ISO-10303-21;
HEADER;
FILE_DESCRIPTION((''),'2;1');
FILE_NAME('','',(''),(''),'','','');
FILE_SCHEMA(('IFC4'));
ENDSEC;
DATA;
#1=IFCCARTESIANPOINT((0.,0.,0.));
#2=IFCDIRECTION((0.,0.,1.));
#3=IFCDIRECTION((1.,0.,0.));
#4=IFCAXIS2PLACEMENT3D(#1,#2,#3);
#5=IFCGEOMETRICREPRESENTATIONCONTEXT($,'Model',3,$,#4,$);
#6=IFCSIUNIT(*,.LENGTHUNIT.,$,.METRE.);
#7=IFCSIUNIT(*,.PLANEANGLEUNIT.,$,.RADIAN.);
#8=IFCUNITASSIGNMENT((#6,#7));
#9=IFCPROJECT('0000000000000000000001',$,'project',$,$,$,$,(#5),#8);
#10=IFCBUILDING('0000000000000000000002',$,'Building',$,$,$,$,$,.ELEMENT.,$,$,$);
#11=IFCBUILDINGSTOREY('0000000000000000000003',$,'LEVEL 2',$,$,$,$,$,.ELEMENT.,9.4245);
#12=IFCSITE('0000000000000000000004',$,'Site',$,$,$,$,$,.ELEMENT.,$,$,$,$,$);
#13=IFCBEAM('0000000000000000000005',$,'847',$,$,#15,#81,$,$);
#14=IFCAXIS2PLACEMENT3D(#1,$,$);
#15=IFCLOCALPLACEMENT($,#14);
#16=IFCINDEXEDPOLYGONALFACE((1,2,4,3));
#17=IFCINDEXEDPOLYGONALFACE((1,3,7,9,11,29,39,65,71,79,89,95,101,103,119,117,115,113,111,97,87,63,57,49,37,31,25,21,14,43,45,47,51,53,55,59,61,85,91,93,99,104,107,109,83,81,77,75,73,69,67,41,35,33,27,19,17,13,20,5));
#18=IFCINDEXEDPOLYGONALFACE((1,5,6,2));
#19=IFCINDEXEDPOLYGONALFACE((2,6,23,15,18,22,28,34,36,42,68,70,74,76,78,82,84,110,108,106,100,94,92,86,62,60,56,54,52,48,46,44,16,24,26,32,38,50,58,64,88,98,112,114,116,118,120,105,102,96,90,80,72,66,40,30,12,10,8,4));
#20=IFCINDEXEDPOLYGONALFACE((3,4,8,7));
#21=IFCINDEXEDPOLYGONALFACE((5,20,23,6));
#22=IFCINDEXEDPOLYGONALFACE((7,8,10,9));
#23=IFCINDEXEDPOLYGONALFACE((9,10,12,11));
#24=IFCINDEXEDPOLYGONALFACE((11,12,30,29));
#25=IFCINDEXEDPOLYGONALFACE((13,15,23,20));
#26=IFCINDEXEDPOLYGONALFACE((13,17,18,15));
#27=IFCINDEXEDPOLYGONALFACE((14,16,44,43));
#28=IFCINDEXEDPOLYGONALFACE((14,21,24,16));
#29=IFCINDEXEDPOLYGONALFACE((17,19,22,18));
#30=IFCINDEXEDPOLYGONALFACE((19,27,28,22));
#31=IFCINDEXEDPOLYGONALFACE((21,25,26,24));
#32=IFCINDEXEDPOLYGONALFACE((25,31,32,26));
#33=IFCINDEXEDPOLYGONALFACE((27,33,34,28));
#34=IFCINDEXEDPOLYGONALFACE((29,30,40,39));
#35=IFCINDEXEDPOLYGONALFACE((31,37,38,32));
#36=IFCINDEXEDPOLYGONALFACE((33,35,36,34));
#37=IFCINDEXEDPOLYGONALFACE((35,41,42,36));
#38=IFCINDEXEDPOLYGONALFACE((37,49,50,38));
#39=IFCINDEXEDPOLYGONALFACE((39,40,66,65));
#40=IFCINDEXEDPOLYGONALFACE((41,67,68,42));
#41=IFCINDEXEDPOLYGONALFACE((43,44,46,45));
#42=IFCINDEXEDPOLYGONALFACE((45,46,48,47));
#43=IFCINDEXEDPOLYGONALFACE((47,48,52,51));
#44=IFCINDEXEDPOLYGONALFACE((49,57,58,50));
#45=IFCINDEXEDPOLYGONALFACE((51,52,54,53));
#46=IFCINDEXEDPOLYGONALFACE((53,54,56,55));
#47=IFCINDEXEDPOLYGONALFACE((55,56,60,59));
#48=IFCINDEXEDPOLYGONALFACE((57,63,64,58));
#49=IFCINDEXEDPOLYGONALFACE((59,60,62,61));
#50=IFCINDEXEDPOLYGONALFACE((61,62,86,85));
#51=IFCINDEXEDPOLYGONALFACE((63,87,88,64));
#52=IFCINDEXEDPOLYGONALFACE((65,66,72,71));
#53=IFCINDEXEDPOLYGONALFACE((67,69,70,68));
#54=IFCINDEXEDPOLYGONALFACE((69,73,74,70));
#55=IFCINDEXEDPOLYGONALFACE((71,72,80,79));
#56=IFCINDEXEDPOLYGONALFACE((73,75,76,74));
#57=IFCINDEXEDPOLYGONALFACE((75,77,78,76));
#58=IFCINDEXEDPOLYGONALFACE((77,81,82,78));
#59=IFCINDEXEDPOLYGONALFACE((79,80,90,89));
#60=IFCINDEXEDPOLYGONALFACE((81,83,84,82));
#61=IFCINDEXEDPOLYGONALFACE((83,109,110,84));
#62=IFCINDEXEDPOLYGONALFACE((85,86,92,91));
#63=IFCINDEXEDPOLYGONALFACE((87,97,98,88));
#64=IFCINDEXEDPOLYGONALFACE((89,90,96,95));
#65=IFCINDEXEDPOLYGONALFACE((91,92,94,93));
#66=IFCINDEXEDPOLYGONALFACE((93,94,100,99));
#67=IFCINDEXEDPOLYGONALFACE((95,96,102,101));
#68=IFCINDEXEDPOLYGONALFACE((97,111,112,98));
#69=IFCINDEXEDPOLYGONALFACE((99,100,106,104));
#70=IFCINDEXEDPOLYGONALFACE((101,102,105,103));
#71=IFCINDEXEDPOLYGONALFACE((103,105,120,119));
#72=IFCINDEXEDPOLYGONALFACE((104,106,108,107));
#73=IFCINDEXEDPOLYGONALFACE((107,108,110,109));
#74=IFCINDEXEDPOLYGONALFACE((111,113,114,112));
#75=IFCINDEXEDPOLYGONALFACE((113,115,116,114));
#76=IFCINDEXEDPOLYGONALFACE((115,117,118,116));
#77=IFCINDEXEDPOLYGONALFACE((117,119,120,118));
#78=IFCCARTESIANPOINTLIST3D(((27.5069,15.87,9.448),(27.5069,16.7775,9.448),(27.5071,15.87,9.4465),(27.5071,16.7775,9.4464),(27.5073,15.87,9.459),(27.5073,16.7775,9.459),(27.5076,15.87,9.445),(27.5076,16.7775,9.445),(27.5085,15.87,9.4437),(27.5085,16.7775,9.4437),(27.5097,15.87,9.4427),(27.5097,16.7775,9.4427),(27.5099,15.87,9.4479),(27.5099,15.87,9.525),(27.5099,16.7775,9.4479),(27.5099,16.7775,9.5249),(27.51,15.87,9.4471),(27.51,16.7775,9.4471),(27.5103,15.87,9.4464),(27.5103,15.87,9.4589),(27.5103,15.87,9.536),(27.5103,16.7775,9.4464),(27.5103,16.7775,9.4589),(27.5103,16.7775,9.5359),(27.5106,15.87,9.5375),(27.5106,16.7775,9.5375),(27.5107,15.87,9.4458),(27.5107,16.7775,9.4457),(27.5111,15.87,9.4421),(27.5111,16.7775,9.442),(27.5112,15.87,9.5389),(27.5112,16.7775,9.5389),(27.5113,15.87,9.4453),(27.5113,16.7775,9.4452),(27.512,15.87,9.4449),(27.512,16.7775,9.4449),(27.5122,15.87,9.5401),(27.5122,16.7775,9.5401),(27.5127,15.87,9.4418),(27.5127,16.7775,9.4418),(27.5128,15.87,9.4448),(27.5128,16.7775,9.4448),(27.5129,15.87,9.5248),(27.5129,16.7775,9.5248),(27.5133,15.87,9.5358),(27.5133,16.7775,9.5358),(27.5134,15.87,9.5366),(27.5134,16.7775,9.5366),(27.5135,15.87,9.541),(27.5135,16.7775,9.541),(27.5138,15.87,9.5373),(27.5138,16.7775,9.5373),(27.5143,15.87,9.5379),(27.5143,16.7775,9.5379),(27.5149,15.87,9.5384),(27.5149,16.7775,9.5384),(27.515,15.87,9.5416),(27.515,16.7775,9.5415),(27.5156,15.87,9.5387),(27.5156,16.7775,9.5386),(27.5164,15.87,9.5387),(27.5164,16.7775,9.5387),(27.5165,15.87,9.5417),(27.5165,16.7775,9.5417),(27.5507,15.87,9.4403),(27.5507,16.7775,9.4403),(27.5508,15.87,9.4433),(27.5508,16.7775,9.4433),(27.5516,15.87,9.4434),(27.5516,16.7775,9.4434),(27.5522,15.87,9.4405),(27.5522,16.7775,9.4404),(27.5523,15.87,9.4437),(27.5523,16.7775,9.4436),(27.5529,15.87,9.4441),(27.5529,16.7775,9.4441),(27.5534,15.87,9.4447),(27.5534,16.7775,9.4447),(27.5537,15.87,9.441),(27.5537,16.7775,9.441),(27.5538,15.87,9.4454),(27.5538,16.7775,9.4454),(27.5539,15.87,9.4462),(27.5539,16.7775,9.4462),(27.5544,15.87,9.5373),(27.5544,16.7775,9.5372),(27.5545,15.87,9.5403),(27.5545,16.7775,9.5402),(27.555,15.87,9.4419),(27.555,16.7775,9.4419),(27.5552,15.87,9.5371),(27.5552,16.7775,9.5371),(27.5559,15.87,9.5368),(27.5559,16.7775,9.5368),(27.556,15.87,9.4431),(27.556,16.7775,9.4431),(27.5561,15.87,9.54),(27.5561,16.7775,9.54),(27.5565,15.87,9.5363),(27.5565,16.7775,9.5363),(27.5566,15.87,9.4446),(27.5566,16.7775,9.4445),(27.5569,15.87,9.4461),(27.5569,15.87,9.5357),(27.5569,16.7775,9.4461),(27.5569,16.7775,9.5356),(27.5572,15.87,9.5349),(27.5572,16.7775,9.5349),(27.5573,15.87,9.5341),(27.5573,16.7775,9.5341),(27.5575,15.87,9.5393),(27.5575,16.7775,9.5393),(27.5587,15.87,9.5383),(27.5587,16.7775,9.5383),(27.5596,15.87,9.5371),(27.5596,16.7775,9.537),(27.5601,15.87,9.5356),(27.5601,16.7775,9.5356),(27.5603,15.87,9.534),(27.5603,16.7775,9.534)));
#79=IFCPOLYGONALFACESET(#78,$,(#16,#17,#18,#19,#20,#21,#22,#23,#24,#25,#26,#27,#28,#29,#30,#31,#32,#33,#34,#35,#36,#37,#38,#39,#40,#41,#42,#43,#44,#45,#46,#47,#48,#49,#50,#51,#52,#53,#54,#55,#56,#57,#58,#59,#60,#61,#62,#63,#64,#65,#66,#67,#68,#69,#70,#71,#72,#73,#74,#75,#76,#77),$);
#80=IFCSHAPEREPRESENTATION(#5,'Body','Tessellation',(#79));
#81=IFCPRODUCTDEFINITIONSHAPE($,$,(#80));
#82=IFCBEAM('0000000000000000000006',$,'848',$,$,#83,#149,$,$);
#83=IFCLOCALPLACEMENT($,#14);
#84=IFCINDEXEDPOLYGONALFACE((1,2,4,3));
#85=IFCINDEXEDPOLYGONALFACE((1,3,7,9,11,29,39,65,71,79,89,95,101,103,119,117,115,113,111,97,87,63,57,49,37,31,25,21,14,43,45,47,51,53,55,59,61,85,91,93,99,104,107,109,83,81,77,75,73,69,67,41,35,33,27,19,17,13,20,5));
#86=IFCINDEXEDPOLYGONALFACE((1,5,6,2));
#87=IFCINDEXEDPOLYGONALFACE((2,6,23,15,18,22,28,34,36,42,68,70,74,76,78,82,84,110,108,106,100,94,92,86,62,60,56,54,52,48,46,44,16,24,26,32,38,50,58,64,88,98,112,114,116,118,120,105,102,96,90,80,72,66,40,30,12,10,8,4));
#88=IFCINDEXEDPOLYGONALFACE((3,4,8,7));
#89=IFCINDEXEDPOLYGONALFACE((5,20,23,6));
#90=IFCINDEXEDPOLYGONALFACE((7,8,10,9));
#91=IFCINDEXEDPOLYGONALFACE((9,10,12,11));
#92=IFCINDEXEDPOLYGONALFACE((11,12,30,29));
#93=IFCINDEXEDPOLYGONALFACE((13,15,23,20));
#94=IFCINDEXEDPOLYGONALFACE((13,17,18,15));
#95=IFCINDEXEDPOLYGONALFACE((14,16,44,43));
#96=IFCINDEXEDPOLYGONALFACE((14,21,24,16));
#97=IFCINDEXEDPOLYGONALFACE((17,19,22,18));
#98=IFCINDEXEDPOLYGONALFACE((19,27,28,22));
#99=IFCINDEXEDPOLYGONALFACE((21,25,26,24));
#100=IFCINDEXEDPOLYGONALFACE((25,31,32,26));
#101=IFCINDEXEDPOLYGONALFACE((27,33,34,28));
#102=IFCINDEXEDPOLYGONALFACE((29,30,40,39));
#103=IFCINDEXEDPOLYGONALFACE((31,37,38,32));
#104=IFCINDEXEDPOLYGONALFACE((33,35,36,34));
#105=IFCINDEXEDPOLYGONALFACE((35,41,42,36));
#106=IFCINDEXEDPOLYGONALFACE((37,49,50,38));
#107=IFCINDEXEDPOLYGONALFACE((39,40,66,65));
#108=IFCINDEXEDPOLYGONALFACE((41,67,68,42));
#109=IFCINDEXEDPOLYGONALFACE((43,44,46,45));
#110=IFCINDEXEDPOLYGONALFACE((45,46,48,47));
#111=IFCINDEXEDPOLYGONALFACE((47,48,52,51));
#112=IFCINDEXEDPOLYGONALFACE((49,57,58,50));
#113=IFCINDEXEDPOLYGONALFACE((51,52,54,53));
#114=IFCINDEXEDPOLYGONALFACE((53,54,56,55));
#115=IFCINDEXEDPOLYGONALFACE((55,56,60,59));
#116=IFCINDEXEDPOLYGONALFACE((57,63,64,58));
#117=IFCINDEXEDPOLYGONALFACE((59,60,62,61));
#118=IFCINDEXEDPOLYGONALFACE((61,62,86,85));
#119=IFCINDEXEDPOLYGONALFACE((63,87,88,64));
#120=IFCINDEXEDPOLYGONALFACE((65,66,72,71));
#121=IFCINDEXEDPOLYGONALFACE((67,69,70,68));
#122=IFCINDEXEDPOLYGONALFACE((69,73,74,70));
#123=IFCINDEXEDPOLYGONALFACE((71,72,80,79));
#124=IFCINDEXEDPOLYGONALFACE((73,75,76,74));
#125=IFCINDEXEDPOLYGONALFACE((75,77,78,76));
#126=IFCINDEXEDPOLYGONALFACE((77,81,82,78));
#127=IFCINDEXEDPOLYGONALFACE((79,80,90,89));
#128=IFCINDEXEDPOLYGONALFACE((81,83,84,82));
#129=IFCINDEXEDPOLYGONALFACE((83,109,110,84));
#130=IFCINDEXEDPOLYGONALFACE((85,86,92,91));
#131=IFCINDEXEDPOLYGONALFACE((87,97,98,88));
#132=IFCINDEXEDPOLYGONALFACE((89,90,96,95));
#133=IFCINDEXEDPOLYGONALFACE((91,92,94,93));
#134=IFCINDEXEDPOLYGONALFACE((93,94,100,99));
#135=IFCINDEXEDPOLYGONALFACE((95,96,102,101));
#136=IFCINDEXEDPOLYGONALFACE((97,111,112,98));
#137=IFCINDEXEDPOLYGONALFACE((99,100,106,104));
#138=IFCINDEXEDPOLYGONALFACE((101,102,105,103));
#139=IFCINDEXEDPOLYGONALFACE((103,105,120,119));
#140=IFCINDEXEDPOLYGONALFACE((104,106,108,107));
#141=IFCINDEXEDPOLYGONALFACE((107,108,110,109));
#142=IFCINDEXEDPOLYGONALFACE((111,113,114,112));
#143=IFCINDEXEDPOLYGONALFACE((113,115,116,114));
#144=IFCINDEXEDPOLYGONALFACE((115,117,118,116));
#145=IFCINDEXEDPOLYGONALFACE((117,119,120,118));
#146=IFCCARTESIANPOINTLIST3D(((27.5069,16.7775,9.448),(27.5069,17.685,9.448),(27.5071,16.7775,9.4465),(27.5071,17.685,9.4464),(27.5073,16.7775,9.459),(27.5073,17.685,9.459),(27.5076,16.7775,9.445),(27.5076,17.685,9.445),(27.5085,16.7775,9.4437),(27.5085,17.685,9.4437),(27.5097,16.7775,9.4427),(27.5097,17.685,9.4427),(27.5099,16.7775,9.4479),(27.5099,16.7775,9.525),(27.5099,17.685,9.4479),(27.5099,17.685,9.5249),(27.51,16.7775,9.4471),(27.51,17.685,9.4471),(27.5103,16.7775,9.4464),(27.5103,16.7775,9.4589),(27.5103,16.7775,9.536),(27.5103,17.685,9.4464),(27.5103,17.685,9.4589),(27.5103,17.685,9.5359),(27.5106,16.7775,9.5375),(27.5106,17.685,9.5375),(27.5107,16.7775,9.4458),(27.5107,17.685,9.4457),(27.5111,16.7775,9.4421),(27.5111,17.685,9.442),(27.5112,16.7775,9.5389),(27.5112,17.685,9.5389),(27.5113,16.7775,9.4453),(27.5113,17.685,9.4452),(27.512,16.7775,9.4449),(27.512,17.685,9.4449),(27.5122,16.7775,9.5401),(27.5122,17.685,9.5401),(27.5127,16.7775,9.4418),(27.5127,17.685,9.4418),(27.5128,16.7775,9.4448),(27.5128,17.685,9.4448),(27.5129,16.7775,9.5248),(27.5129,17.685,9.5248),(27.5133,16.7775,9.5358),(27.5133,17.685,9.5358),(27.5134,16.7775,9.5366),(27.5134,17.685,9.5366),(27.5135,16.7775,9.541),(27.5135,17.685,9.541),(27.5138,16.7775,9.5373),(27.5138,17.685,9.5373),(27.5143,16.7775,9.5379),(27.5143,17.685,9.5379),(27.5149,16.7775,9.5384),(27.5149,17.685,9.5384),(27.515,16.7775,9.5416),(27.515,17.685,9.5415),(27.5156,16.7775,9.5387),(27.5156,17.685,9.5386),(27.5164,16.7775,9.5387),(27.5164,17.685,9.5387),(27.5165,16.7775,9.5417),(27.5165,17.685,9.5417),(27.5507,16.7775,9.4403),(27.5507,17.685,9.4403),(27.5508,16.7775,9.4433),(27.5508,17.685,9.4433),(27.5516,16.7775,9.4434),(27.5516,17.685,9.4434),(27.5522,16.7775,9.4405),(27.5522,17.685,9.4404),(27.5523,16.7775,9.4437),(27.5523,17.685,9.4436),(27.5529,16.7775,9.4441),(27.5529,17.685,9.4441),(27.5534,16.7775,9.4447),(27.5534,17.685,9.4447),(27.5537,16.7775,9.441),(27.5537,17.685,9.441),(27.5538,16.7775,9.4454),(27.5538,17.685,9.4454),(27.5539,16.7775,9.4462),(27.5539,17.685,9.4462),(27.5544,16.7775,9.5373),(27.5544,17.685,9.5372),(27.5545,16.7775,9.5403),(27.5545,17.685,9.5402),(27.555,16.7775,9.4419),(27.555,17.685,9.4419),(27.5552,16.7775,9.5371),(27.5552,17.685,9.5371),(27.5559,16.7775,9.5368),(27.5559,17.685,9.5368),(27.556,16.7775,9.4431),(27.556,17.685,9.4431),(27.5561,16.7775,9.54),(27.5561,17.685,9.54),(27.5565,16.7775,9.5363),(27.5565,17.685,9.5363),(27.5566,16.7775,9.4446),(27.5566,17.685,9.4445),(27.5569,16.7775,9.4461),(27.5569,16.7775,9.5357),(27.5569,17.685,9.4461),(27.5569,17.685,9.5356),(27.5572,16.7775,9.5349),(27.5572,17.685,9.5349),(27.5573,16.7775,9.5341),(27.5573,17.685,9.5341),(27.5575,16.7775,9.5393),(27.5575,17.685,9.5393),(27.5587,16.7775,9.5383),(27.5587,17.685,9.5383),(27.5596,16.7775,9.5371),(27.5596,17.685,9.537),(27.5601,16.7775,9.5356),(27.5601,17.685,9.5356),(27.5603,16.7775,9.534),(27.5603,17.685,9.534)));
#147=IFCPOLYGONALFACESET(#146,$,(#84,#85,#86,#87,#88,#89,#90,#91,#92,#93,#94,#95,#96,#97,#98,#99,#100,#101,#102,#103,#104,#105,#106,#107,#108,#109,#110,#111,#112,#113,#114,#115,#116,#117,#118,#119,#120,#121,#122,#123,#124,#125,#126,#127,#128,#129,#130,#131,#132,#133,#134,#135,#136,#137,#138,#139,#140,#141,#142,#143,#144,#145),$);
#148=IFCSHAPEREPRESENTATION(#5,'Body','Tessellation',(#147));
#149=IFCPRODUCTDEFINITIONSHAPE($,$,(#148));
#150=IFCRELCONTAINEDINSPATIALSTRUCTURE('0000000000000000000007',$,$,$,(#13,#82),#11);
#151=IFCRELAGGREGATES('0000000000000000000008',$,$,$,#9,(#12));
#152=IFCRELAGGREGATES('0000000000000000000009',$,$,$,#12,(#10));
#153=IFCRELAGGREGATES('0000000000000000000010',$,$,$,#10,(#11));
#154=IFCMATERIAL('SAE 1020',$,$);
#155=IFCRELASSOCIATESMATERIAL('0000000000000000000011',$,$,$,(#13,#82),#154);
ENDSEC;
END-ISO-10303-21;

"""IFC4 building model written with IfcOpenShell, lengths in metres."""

from ifc_helpers import new_model, si_unit, frame, origin_with_axes, origin_2d_with_axis, place, context, project, spatial, c_section, extrude, material, material_profile, profile_set, profile_usage, element, save


model = new_model("IFC4")

# Units and contexts
model_context = context("Model", 3, world=origin_with_axes())
ifc_project = project(units=[si_unit("LENGTHUNIT", "METRE"), si_unit("PLANEANGLEUNIT", "RADIAN")], contexts=[model_context])

# Site, building, storey
site = spatial("IfcSite", under=ifc_project, Name="Site", CompositionType="ELEMENT")
building = spatial("IfcBuilding", under=site, Name="Building", CompositionType="ELEMENT")
storey = spatial("IfcBuildingStorey", under=building, Name="LEVEL 2", CompositionType="ELEMENT", Elevation=9.4245)

# Beams
ifc_material = material(Name="SAE 1020")
ifc_material_profile_1 = material_profile(ifc_material, c_section(Depth=0.1, Width=0.05, WallThickness=0.003, Girth=0.017, InternalFilletRadius=0.003, at=origin_2d_with_axis()))
ifc_profile_set_1 = profile_set([ifc_material_profile_1])
ifc_profile_usage_1 = profile_usage(ifc_profile_set_1, cardinal=10)
beam_1_placement = place(None, frame((27.5336, 15.87, 9.491), z_axis=(0.0, 1.0, -0.00003), x_axis=(-0.999256, 0.000001, 0.038562)))
element("IfcBeam", 1, at=beam_1_placement, inside=storey, material=ifc_profile_usage_1, Name="847", context=model_context, shape_type="SweptSolid", body=[
    extrude(c_section(Depth=0.1, Width=0.05, WallThickness=0.003, Girth=0.017, InternalFilletRadius=0.003, at=origin_2d_with_axis()), origin_with_axes(), (0.0, 0.0, 1.0), 0.9075),
])
ifc_material_profile_2 = material_profile(ifc_material, c_section(Depth=0.1, Width=0.05, WallThickness=0.003, Girth=0.017, InternalFilletRadius=0.003, at=origin_2d_with_axis()))
ifc_profile_set_2 = profile_set([ifc_material_profile_2])
ifc_profile_usage_2 = profile_usage(ifc_profile_set_2, cardinal=10)
beam_2_placement = place(None, frame((27.5336, 16.7775, 9.491), z_axis=(0.0, 1.0, -0.00003), x_axis=(-0.999256, 0.000001, 0.038562)))
element("IfcBeam", 2, at=beam_2_placement, inside=storey, material=ifc_profile_usage_2, Name="848", context=model_context, shape_type="SweptSolid", body=[
    extrude(c_section(Depth=0.1, Width=0.05, WallThickness=0.003, Girth=0.017, InternalFilletRadius=0.003, at=origin_2d_with_axis()), origin_with_axes(), (0.0, 0.0, 1.0), 0.9075),
])

save(model, "model.ifc")
